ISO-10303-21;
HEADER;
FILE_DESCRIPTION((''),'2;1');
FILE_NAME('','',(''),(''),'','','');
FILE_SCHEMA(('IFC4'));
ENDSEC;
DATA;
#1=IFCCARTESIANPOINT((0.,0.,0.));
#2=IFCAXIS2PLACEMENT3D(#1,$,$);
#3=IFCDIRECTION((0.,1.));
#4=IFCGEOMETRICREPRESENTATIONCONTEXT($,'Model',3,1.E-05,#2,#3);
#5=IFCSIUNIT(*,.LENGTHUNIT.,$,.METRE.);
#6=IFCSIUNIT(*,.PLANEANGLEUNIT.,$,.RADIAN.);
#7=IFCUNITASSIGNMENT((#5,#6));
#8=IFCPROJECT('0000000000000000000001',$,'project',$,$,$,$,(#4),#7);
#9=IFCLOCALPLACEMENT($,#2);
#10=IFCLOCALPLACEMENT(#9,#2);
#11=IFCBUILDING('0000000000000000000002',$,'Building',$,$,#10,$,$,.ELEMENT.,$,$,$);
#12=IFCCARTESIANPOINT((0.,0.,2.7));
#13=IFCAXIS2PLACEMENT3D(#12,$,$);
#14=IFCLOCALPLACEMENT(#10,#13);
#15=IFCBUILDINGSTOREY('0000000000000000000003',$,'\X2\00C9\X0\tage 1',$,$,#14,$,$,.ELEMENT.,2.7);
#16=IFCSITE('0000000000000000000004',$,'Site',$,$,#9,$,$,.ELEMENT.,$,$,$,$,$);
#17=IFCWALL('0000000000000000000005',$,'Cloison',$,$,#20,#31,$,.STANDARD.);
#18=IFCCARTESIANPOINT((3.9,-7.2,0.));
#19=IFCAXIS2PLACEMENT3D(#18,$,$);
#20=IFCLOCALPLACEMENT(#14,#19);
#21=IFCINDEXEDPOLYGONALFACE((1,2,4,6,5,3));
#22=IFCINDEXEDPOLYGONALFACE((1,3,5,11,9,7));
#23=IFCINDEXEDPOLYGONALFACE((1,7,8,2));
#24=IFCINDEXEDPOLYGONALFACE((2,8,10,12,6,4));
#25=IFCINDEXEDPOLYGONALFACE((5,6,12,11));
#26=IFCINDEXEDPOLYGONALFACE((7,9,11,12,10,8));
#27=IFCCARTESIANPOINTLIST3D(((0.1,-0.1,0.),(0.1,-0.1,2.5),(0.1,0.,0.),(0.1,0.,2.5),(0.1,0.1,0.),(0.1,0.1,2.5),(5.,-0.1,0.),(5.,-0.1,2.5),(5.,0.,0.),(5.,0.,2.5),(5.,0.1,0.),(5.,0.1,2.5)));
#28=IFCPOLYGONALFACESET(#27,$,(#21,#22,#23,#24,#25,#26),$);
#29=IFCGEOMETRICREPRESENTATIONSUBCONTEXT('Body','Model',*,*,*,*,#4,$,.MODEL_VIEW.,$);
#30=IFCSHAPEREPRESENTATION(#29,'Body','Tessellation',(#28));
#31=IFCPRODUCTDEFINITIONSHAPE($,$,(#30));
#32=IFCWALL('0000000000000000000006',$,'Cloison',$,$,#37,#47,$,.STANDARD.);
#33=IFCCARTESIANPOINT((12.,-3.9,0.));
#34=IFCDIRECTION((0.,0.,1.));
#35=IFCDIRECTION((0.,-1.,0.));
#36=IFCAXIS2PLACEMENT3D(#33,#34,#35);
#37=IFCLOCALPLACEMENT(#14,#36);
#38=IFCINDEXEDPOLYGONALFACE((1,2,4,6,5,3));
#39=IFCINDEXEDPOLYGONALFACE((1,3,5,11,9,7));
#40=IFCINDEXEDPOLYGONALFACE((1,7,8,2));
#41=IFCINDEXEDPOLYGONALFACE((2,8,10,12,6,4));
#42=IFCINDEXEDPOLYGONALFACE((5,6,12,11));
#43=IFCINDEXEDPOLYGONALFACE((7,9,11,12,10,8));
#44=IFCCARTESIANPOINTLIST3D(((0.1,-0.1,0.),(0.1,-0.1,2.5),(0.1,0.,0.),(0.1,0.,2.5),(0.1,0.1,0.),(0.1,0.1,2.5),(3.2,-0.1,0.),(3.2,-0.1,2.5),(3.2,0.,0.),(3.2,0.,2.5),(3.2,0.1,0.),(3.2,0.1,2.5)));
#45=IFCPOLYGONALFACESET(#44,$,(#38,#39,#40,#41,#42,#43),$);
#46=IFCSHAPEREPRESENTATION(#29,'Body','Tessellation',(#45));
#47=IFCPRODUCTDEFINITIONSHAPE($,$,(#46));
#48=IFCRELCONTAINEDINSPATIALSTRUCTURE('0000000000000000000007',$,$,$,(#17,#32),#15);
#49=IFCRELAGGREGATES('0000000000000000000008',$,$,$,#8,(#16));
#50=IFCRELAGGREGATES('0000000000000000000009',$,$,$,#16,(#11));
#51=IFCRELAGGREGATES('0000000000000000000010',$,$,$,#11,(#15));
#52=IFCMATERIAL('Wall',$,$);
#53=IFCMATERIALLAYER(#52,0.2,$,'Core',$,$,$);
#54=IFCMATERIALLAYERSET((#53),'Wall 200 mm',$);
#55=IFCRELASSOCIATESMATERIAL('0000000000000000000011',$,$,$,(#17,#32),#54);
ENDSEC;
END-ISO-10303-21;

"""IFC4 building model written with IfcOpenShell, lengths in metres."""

from ifc_helpers import new_model, si_unit, direction, frame, origin, place, context, subcontext, project, spatial, polyline, outline, extrude, material, layer, layer_set, layer_usage, element, save


model = new_model("IFC4")

# Units and contexts
model_context = context("Model", 3, precision=1e-05, world=origin(), true_north=direction((0.0, 1.0)))
body_context = subcontext(model_context, "Body", "Model", "MODEL_VIEW")
ifc_project = project(units=[si_unit("LENGTHUNIT", "METRE"), si_unit("PLANEANGLEUNIT", "RADIAN")], contexts=[model_context])

# Site, building, storey
site_placement = place(None, origin())
site = spatial("IfcSite", under=ifc_project, at=site_placement, Name="Site", CompositionType="ELEMENT")
building_placement = place(site_placement, origin())
building = spatial("IfcBuilding", under=site, at=building_placement, Name="Building", CompositionType="ELEMENT")
storey_placement = place(building_placement, frame((0.0, 0.0, 2.7)))
storey = spatial("IfcBuildingStorey", under=building, at=storey_placement, Name="Étage 1", CompositionType="ELEMENT", Elevation=2.7)

# Shared definitions
ifc_material = material(Name="Wall")
ifc_layer = layer(ifc_material, 0.2, Name="Core")
ifc_layer_set = layer_set([ifc_layer], Name="Wall 200 mm")
ifc_layer_usage = layer_usage(ifc_layer_set, "AXIS2", "POSITIVE", -0.1)

# Wall
wall_1_placement = place(storey_placement, frame((3.9, -7.2, 0.0)))
element("IfcWall", 1, at=wall_1_placement, inside=storey, material=ifc_layer_usage, Name="Cloison", PredefinedType="STANDARD", context=body_context, shape_type="SweptSolid", body=[
    extrude(outline(polyline([(0.1, 0.0), (0.1, -0.1), (5.0, -0.1), (5.0, 0.0), (5.0, 0.1), (0.1, 0.1), (0.1, 0.0)])), origin(), (0.0, 0.0, 1.0), 2.5),
])

# Wall
wall_2_placement = place(storey_placement, frame((12.0, -3.9, 0.0), z_axis=(0.0, 0.0, 1.0), x_axis=(0.0, -1.0, 0.0)))
element("IfcWall", 2, at=wall_2_placement, inside=storey, material=ifc_layer_usage, Name="Cloison", PredefinedType="STANDARD", context=body_context, shape_type="SweptSolid", body=[
    extrude(outline(polyline([(0.1, 0.0), (0.1, -0.1), (3.2, -0.1), (3.2, 0.0), (3.2, 0.1), (0.1, 0.1), (0.1, 0.0)])), origin(), (0.0, 0.0, 1.0), 2.5),
])

save(model, "model.ifc")
